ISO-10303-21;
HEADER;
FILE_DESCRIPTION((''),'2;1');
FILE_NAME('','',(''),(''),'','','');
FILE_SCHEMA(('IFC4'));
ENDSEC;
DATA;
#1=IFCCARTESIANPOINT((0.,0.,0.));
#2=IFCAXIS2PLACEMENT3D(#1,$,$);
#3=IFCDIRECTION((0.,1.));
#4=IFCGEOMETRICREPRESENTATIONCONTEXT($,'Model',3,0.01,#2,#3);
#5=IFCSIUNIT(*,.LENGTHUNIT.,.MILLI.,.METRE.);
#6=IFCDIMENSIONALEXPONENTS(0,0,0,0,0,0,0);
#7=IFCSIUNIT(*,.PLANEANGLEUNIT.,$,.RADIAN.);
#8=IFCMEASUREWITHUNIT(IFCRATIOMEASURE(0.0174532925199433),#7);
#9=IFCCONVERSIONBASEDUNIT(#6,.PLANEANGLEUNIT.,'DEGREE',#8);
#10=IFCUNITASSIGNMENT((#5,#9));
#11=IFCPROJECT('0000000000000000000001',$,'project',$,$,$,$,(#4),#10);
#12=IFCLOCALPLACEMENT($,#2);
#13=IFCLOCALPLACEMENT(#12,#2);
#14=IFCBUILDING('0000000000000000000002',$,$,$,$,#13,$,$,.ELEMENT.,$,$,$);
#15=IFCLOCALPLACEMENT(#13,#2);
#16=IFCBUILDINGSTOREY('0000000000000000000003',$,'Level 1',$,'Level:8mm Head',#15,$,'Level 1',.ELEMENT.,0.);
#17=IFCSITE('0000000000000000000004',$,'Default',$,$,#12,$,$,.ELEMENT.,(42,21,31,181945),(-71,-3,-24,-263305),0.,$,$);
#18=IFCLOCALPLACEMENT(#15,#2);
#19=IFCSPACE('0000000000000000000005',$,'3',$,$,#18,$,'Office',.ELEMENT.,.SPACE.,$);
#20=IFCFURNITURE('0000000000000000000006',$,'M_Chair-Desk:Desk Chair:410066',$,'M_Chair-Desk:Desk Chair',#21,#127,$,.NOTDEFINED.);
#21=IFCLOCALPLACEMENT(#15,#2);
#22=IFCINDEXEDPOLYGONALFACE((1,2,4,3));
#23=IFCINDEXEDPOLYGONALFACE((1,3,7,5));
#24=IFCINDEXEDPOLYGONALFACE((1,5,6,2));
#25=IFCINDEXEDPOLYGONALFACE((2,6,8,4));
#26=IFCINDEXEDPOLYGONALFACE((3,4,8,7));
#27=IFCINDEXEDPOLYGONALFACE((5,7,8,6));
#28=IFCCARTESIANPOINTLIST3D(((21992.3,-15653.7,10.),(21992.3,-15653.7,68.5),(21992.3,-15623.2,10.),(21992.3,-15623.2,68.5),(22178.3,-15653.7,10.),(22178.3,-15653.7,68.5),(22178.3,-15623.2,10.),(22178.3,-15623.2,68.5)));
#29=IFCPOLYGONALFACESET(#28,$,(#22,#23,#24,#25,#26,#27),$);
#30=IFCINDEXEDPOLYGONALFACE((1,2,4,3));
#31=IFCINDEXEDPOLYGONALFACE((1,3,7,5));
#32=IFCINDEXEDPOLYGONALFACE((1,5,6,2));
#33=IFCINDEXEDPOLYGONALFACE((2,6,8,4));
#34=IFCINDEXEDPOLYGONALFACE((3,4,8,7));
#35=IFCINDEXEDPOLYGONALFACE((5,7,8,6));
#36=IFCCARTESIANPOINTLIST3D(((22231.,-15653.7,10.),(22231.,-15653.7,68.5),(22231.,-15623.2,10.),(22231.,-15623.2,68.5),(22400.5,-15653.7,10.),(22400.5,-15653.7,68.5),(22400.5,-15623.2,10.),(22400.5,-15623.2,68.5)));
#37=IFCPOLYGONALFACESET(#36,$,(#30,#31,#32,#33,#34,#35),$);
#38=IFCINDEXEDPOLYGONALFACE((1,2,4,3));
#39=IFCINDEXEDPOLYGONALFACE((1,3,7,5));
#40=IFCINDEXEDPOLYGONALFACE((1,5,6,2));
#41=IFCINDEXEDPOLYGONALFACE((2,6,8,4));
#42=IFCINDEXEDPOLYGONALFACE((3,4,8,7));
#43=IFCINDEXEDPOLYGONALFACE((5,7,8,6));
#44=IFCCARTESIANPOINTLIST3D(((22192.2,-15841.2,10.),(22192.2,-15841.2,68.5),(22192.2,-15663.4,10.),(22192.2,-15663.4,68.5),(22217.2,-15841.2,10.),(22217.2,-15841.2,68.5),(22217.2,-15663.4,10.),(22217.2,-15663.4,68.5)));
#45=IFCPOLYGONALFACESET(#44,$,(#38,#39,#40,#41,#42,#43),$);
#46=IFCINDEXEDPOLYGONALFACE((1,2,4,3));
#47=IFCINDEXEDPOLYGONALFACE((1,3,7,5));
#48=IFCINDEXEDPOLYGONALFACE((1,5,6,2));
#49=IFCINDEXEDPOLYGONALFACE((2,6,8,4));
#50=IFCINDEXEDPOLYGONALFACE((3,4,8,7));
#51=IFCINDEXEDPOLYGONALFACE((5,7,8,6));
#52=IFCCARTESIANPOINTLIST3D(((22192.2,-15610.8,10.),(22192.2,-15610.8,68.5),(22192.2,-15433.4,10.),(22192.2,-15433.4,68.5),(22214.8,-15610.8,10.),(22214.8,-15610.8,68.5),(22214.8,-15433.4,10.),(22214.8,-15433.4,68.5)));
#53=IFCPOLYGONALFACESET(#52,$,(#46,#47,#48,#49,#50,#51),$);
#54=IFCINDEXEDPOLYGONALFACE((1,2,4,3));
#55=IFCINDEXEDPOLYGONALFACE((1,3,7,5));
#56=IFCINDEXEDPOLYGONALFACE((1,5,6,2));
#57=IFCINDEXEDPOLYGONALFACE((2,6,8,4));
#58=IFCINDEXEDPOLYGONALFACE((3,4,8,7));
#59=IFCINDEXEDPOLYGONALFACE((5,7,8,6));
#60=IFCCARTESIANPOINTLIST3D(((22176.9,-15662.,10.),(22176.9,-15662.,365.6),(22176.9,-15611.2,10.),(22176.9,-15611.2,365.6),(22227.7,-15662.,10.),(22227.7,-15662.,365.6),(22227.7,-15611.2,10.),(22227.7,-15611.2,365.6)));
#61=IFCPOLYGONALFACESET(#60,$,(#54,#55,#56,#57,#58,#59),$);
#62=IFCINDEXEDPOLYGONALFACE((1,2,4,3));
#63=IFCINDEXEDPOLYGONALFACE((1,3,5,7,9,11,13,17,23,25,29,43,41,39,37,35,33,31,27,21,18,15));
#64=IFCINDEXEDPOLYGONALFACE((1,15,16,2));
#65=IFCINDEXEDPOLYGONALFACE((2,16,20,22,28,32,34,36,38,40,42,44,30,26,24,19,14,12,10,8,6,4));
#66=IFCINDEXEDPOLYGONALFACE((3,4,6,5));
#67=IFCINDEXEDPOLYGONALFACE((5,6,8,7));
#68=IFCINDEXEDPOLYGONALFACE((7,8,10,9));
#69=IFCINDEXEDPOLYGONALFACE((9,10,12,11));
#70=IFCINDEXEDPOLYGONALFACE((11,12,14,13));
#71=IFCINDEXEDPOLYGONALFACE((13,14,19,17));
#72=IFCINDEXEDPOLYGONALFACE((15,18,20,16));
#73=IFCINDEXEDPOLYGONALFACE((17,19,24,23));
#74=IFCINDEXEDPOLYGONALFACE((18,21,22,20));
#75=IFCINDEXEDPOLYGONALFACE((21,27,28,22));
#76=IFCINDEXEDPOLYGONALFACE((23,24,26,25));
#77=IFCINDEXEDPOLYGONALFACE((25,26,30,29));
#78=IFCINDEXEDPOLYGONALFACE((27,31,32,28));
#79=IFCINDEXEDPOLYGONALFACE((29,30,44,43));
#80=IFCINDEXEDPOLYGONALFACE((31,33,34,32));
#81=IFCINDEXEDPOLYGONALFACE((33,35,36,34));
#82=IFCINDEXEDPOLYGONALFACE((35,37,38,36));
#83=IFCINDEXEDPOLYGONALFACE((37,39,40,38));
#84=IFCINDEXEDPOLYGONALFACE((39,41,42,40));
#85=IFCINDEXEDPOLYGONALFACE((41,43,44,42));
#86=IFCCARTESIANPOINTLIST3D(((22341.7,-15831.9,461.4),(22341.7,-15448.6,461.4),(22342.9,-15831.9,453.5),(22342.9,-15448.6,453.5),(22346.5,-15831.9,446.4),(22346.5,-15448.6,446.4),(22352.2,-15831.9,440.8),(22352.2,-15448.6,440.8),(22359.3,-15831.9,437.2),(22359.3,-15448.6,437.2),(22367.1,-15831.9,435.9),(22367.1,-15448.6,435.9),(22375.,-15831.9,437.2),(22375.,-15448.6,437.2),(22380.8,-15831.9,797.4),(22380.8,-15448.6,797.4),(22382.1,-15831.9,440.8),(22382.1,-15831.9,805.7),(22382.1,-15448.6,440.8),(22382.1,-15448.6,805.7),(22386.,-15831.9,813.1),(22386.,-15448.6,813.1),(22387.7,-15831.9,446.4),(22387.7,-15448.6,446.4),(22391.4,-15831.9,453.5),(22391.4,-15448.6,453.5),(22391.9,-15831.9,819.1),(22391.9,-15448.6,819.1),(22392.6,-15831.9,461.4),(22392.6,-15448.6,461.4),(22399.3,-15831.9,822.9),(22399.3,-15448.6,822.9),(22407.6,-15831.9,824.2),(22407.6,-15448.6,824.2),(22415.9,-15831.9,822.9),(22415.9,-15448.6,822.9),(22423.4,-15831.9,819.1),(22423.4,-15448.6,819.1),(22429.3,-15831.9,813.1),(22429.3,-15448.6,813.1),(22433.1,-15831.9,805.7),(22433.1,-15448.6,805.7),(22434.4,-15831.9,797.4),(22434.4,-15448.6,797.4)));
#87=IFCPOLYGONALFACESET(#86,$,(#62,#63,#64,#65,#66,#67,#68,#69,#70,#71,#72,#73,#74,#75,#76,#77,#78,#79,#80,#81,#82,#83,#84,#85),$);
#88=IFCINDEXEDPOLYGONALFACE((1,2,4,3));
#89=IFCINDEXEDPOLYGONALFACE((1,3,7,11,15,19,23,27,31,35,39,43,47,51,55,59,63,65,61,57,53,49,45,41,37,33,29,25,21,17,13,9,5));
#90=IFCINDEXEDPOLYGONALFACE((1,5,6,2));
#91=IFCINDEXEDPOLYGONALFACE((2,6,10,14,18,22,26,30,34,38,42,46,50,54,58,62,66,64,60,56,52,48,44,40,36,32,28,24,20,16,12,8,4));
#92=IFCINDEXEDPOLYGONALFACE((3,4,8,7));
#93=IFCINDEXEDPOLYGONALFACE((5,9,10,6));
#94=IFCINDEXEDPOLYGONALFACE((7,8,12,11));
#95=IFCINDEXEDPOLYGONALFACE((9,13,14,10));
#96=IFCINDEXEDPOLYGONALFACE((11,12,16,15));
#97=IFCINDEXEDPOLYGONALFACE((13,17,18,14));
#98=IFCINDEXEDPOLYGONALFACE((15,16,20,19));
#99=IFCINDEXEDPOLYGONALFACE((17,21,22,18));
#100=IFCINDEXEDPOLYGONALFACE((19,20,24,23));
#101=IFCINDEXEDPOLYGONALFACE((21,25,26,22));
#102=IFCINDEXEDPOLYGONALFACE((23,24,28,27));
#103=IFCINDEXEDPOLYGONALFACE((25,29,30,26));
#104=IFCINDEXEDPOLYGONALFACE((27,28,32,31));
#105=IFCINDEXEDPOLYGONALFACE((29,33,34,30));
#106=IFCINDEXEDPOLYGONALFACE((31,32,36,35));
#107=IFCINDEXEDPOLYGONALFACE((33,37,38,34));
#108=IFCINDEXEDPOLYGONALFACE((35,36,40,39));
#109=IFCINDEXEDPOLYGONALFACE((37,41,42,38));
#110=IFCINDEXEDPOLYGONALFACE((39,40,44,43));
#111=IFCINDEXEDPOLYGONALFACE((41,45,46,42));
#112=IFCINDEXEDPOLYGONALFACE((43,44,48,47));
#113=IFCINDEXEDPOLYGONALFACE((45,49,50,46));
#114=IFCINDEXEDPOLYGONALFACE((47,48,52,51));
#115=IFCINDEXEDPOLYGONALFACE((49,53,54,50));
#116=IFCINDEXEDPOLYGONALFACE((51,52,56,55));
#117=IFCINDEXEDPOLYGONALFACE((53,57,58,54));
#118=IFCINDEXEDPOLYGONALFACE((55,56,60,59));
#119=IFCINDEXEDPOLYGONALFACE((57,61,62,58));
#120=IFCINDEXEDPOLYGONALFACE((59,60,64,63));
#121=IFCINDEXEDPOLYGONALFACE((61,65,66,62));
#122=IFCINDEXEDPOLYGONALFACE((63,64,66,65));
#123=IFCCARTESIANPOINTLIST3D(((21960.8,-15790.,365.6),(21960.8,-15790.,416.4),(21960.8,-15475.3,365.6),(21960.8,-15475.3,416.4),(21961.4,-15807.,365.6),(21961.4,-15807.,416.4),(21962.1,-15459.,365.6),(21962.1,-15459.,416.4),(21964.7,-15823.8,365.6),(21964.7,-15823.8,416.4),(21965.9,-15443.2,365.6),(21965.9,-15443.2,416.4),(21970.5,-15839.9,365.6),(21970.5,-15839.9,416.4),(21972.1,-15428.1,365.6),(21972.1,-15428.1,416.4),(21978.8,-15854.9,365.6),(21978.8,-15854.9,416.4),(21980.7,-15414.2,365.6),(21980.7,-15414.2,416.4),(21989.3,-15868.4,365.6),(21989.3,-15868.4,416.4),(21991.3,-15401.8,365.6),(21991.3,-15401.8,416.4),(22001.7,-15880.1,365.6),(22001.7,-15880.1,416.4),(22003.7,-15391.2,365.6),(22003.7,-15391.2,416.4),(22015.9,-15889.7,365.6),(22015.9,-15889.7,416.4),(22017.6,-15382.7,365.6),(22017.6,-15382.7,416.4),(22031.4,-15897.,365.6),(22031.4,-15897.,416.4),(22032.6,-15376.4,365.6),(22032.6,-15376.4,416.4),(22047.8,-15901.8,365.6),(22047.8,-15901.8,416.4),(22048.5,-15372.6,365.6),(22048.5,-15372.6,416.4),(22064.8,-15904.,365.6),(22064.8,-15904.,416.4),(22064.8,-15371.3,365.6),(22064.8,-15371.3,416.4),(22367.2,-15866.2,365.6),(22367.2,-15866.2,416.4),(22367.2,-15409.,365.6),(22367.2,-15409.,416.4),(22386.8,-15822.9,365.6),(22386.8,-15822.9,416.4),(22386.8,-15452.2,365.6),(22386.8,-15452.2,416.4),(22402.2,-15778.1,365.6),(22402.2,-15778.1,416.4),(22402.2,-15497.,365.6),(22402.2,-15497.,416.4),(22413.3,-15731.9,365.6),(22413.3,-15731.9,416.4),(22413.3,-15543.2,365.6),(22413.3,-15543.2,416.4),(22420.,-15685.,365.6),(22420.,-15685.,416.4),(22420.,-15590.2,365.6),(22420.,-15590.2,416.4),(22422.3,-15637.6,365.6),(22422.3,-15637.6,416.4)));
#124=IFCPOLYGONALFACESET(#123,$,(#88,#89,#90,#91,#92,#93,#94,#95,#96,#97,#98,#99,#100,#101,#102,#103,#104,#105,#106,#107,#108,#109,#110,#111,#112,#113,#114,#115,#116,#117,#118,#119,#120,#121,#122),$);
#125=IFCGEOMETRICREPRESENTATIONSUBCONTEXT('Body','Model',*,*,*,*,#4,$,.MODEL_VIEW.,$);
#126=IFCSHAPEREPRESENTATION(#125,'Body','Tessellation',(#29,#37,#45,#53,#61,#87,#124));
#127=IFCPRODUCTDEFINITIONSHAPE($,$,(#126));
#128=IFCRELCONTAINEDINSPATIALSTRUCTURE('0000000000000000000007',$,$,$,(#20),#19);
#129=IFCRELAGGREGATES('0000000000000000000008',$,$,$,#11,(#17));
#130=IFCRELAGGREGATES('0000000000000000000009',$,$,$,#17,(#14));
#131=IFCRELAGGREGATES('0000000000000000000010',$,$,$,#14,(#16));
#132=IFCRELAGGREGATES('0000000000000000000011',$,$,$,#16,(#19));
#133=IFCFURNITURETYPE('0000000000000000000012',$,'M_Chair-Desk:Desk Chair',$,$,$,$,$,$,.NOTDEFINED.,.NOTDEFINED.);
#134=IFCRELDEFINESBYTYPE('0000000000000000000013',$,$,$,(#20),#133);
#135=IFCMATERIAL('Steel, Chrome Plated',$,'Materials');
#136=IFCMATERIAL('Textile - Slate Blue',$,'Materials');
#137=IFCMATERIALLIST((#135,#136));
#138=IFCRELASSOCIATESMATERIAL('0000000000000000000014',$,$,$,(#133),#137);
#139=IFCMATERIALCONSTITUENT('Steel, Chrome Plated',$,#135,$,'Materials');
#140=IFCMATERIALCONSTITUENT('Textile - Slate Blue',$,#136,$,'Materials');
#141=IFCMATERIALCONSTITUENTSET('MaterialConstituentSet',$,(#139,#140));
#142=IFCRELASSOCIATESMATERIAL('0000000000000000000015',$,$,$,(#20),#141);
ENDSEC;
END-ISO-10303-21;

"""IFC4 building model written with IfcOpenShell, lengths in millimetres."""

from ifc_helpers import new_model, entity, si_unit, converted_unit, direction, frame, origin, place, context, subcontext, project, spatial, indexed_curve, outline, extrude, source, transform, mapped, material, material_list, constituent, constituent_set, type_object, type_shapes, element, save


model = new_model("IFC4")

# Units and contexts
model_context = context("Model", 3, precision=0.01, world=origin(), true_north=direction((0.0, 1.0)))
body_context = subcontext(model_context, "Body", "Model", "MODEL_VIEW")
ifc_project = project(units=[si_unit("LENGTHUNIT", "METRE", prefix="MILLI"), converted_unit("PLANEANGLEUNIT", "DEGREE", entity("IfcRatioMeasure", 0.0174532925199433), si_unit("PLANEANGLEUNIT", "RADIAN"), dimensions=[0, 0, 0, 0, 0, 0, 0])], contexts=[model_context])

# Site, building, storey
site_placement = place(None, origin())
site = spatial("IfcSite", under=ifc_project, at=site_placement, Name="Default", CompositionType="ELEMENT", RefLatitude=(42, 21, 31, 181945), RefLongitude=(-71, -3, -24, -263305), RefElevation=0.0)
building_placement = place(site_placement, origin())
building = spatial("IfcBuilding", under=site, at=building_placement, CompositionType="ELEMENT")
storey_placement = place(building_placement, origin())
storey = spatial("IfcBuildingStorey", under=building, at=storey_placement, Name="Level 1", ObjectType="Level:8mm Head", LongName="Level 1", CompositionType="ELEMENT", Elevation=0.0)

# Shared definitions
space_placement = place(storey_placement, origin())
space = spatial("IfcSpace", under=storey, at=space_placement, Name="3", LongName="Office", CompositionType="ELEMENT", PredefinedType="SPACE")

# Furniture
ifc_material_1 = material(Name="Steel, Chrome Plated", Category="Materials")
ifc_constituent_1 = constituent(ifc_material_1, Name="Steel, Chrome Plated", Category="Materials")
ifc_material_2 = material(Name="Textile - Slate Blue", Category="Materials")
ifc_constituent_2 = constituent(ifc_material_2, Name="Textile - Slate Blue", Category="Materials")
ifc_constituent_set_1 = constituent_set(constituents=[ifc_constituent_1, ifc_constituent_2], Name="MaterialConstituentSet")
ifc_material_list_1 = material_list([ifc_material_1, ifc_material_2])
furniture_type = type_object("IfcFurnitureType", Name="M_Chair-Desk:Desk Chair", AssemblyPlace="NOTDEFINED", PredefinedType="NOTDEFINED", material=ifc_material_list_1)
shared_shape_1 = source(origin(), body_context, "Body", "SweptSolid", [
    extrude(outline(indexed_curve([(-15.2, -93.0), (15.2, -93.0), (15.2, 93.0), (-15.2, 93.0), (-15.2, -93.0)], self_intersect=False)), frame((-0.9, 281.9, 0.0)), (0.0, 0.0, 1.0), 58.5),
    extrude(outline(indexed_curve([(-15.2, -84.7), (15.2, -84.7), (15.2, 84.7), (-15.2, 84.7), (-15.2, -84.7)], self_intersect=False)), frame((-0.9, 51.5, 0.0), z_axis=(0.0, 0.0, 1.0), x_axis=(-1.0, 0.0, 0.0)), (0.0, 0.0, 1.0), 58.5),
    extrude(outline(indexed_curve([(-12.5, -88.9), (12.5, -88.9), (12.5, 88.9), (-12.5, 88.9), (-12.5, -88.9)], self_intersect=False)), frame((-114.8, 162.5, 0.0), z_axis=(0.0, 0.0, 1.0), x_axis=(0.0, -1.0, 0.0)), (0.0, 0.0, 1.0), 58.5),
    extrude(outline(indexed_curve([(-88.7, -11.3), (88.7, -11.3), (88.7, 11.3), (-88.7, 11.3), (-88.7, -11.3)], self_intersect=False)), frame((115.5, 163.7, 0.0), z_axis=(0.0, 0.0, 1.0), x_axis=(-1.0, 0.0, 0.0)), (0.0, 0.0, 1.0), 58.5),
    extrude(outline(indexed_curve([(-25.4, -25.4), (25.4, -25.4), (25.4, 25.4), (-25.4, 25.4), (-25.4, -25.4)], self_intersect=False)), frame((0.9, 164.9, 0.0), z_axis=(0.0, 0.0, 1.0), x_axis=(-1.0, 0.0, 0.0)), (0.0, 0.0, 1.0), 355.6),
    extrude(outline(indexed_curve([(6.5, 168.0), (5.2, 176.3), (1.4, 183.8), (-4.5, 189.7), (-12.0, 193.5), (-20.2, 194.8), (-28.5, 193.5), (-36.0, 189.7), (-41.9, 183.8), (-45.7, 176.3), (-47.0, 168.0), (-5.2, -168.0), (-4.0, -175.9), (-0.4, -183.0), (5.3, -188.6), (12.4, -192.2), (20.2, -193.5), (28.1, -192.2), (35.2, -188.6), (40.9, -183.0), (44.5, -175.9), (45.7, -168.0), (6.5, 168.0)], self_intersect=False)), frame((-194.4, -20.2, 619.4), z_axis=(1.0, 0.0, 0.0), x_axis=(0.0, 1.0, 0.0)), (0.0, 0.0, 1.0), 383.3),
    extrude(outline(indexed_curve([(-98.9, -257.7), (205.9, -257.7), (230.7, -217.3), (251.6, -174.7), (268.3, -130.3), (280.8, -84.5), (288.9, -37.7), (292.6, 9.6), (291.7, 57.0), (286.4, 104.2), (276.7, 150.6), (262.6, 195.9), (-32.8, 270.8), (-49.1, 271.5), (-65.3, 269.7), (-81.1, 265.4), (-95.9, 258.6), (-109.5, 249.7), (-121.6, 238.7), (-131.8, 225.9), (-139.8, 211.7), (-145.6, 196.5), (-148.9, 180.5), (-187.9, -131.7), (-189.4, -148.8), (-188.3, -165.8), (-184.5, -182.5), (-178.1, -198.4), (-169.4, -213.1), (-158.5, -226.2), (-145.6, -237.5), (-131.2, -246.7), (-115.5, -253.5), (-98.9, -257.7)], self_intersect=False)), frame((1.6, 236.3, 355.6), z_axis=(0.0, 0.0, 1.0), x_axis=(0.124035, -0.992278, 0.0)), (0.0, 0.0, 1.0), 50.8),
])
type_shapes(furniture_type, [shared_shape_1])
furniture_1_placement = place(space_placement, frame((22367.2, -15637.6, 10.0), z_axis=(0.0, 0.0, 1.0), x_axis=(0.0, 1.0, 0.0)))
element("IfcFurniture", 1, at=furniture_1_placement, inside=space, type_object=furniture_type, material=ifc_constituent_set_1, Name="M_Chair-Desk:Desk Chair:410066", ObjectType="M_Chair-Desk:Desk Chair", PredefinedType="NOTDEFINED", context=body_context, shape_type="MappedRepresentation", body=[
    mapped(shared_shape_1, transform((0.0, 0.0, 0.0), scale=1.0)),
])

save(model, "model.ifc")
